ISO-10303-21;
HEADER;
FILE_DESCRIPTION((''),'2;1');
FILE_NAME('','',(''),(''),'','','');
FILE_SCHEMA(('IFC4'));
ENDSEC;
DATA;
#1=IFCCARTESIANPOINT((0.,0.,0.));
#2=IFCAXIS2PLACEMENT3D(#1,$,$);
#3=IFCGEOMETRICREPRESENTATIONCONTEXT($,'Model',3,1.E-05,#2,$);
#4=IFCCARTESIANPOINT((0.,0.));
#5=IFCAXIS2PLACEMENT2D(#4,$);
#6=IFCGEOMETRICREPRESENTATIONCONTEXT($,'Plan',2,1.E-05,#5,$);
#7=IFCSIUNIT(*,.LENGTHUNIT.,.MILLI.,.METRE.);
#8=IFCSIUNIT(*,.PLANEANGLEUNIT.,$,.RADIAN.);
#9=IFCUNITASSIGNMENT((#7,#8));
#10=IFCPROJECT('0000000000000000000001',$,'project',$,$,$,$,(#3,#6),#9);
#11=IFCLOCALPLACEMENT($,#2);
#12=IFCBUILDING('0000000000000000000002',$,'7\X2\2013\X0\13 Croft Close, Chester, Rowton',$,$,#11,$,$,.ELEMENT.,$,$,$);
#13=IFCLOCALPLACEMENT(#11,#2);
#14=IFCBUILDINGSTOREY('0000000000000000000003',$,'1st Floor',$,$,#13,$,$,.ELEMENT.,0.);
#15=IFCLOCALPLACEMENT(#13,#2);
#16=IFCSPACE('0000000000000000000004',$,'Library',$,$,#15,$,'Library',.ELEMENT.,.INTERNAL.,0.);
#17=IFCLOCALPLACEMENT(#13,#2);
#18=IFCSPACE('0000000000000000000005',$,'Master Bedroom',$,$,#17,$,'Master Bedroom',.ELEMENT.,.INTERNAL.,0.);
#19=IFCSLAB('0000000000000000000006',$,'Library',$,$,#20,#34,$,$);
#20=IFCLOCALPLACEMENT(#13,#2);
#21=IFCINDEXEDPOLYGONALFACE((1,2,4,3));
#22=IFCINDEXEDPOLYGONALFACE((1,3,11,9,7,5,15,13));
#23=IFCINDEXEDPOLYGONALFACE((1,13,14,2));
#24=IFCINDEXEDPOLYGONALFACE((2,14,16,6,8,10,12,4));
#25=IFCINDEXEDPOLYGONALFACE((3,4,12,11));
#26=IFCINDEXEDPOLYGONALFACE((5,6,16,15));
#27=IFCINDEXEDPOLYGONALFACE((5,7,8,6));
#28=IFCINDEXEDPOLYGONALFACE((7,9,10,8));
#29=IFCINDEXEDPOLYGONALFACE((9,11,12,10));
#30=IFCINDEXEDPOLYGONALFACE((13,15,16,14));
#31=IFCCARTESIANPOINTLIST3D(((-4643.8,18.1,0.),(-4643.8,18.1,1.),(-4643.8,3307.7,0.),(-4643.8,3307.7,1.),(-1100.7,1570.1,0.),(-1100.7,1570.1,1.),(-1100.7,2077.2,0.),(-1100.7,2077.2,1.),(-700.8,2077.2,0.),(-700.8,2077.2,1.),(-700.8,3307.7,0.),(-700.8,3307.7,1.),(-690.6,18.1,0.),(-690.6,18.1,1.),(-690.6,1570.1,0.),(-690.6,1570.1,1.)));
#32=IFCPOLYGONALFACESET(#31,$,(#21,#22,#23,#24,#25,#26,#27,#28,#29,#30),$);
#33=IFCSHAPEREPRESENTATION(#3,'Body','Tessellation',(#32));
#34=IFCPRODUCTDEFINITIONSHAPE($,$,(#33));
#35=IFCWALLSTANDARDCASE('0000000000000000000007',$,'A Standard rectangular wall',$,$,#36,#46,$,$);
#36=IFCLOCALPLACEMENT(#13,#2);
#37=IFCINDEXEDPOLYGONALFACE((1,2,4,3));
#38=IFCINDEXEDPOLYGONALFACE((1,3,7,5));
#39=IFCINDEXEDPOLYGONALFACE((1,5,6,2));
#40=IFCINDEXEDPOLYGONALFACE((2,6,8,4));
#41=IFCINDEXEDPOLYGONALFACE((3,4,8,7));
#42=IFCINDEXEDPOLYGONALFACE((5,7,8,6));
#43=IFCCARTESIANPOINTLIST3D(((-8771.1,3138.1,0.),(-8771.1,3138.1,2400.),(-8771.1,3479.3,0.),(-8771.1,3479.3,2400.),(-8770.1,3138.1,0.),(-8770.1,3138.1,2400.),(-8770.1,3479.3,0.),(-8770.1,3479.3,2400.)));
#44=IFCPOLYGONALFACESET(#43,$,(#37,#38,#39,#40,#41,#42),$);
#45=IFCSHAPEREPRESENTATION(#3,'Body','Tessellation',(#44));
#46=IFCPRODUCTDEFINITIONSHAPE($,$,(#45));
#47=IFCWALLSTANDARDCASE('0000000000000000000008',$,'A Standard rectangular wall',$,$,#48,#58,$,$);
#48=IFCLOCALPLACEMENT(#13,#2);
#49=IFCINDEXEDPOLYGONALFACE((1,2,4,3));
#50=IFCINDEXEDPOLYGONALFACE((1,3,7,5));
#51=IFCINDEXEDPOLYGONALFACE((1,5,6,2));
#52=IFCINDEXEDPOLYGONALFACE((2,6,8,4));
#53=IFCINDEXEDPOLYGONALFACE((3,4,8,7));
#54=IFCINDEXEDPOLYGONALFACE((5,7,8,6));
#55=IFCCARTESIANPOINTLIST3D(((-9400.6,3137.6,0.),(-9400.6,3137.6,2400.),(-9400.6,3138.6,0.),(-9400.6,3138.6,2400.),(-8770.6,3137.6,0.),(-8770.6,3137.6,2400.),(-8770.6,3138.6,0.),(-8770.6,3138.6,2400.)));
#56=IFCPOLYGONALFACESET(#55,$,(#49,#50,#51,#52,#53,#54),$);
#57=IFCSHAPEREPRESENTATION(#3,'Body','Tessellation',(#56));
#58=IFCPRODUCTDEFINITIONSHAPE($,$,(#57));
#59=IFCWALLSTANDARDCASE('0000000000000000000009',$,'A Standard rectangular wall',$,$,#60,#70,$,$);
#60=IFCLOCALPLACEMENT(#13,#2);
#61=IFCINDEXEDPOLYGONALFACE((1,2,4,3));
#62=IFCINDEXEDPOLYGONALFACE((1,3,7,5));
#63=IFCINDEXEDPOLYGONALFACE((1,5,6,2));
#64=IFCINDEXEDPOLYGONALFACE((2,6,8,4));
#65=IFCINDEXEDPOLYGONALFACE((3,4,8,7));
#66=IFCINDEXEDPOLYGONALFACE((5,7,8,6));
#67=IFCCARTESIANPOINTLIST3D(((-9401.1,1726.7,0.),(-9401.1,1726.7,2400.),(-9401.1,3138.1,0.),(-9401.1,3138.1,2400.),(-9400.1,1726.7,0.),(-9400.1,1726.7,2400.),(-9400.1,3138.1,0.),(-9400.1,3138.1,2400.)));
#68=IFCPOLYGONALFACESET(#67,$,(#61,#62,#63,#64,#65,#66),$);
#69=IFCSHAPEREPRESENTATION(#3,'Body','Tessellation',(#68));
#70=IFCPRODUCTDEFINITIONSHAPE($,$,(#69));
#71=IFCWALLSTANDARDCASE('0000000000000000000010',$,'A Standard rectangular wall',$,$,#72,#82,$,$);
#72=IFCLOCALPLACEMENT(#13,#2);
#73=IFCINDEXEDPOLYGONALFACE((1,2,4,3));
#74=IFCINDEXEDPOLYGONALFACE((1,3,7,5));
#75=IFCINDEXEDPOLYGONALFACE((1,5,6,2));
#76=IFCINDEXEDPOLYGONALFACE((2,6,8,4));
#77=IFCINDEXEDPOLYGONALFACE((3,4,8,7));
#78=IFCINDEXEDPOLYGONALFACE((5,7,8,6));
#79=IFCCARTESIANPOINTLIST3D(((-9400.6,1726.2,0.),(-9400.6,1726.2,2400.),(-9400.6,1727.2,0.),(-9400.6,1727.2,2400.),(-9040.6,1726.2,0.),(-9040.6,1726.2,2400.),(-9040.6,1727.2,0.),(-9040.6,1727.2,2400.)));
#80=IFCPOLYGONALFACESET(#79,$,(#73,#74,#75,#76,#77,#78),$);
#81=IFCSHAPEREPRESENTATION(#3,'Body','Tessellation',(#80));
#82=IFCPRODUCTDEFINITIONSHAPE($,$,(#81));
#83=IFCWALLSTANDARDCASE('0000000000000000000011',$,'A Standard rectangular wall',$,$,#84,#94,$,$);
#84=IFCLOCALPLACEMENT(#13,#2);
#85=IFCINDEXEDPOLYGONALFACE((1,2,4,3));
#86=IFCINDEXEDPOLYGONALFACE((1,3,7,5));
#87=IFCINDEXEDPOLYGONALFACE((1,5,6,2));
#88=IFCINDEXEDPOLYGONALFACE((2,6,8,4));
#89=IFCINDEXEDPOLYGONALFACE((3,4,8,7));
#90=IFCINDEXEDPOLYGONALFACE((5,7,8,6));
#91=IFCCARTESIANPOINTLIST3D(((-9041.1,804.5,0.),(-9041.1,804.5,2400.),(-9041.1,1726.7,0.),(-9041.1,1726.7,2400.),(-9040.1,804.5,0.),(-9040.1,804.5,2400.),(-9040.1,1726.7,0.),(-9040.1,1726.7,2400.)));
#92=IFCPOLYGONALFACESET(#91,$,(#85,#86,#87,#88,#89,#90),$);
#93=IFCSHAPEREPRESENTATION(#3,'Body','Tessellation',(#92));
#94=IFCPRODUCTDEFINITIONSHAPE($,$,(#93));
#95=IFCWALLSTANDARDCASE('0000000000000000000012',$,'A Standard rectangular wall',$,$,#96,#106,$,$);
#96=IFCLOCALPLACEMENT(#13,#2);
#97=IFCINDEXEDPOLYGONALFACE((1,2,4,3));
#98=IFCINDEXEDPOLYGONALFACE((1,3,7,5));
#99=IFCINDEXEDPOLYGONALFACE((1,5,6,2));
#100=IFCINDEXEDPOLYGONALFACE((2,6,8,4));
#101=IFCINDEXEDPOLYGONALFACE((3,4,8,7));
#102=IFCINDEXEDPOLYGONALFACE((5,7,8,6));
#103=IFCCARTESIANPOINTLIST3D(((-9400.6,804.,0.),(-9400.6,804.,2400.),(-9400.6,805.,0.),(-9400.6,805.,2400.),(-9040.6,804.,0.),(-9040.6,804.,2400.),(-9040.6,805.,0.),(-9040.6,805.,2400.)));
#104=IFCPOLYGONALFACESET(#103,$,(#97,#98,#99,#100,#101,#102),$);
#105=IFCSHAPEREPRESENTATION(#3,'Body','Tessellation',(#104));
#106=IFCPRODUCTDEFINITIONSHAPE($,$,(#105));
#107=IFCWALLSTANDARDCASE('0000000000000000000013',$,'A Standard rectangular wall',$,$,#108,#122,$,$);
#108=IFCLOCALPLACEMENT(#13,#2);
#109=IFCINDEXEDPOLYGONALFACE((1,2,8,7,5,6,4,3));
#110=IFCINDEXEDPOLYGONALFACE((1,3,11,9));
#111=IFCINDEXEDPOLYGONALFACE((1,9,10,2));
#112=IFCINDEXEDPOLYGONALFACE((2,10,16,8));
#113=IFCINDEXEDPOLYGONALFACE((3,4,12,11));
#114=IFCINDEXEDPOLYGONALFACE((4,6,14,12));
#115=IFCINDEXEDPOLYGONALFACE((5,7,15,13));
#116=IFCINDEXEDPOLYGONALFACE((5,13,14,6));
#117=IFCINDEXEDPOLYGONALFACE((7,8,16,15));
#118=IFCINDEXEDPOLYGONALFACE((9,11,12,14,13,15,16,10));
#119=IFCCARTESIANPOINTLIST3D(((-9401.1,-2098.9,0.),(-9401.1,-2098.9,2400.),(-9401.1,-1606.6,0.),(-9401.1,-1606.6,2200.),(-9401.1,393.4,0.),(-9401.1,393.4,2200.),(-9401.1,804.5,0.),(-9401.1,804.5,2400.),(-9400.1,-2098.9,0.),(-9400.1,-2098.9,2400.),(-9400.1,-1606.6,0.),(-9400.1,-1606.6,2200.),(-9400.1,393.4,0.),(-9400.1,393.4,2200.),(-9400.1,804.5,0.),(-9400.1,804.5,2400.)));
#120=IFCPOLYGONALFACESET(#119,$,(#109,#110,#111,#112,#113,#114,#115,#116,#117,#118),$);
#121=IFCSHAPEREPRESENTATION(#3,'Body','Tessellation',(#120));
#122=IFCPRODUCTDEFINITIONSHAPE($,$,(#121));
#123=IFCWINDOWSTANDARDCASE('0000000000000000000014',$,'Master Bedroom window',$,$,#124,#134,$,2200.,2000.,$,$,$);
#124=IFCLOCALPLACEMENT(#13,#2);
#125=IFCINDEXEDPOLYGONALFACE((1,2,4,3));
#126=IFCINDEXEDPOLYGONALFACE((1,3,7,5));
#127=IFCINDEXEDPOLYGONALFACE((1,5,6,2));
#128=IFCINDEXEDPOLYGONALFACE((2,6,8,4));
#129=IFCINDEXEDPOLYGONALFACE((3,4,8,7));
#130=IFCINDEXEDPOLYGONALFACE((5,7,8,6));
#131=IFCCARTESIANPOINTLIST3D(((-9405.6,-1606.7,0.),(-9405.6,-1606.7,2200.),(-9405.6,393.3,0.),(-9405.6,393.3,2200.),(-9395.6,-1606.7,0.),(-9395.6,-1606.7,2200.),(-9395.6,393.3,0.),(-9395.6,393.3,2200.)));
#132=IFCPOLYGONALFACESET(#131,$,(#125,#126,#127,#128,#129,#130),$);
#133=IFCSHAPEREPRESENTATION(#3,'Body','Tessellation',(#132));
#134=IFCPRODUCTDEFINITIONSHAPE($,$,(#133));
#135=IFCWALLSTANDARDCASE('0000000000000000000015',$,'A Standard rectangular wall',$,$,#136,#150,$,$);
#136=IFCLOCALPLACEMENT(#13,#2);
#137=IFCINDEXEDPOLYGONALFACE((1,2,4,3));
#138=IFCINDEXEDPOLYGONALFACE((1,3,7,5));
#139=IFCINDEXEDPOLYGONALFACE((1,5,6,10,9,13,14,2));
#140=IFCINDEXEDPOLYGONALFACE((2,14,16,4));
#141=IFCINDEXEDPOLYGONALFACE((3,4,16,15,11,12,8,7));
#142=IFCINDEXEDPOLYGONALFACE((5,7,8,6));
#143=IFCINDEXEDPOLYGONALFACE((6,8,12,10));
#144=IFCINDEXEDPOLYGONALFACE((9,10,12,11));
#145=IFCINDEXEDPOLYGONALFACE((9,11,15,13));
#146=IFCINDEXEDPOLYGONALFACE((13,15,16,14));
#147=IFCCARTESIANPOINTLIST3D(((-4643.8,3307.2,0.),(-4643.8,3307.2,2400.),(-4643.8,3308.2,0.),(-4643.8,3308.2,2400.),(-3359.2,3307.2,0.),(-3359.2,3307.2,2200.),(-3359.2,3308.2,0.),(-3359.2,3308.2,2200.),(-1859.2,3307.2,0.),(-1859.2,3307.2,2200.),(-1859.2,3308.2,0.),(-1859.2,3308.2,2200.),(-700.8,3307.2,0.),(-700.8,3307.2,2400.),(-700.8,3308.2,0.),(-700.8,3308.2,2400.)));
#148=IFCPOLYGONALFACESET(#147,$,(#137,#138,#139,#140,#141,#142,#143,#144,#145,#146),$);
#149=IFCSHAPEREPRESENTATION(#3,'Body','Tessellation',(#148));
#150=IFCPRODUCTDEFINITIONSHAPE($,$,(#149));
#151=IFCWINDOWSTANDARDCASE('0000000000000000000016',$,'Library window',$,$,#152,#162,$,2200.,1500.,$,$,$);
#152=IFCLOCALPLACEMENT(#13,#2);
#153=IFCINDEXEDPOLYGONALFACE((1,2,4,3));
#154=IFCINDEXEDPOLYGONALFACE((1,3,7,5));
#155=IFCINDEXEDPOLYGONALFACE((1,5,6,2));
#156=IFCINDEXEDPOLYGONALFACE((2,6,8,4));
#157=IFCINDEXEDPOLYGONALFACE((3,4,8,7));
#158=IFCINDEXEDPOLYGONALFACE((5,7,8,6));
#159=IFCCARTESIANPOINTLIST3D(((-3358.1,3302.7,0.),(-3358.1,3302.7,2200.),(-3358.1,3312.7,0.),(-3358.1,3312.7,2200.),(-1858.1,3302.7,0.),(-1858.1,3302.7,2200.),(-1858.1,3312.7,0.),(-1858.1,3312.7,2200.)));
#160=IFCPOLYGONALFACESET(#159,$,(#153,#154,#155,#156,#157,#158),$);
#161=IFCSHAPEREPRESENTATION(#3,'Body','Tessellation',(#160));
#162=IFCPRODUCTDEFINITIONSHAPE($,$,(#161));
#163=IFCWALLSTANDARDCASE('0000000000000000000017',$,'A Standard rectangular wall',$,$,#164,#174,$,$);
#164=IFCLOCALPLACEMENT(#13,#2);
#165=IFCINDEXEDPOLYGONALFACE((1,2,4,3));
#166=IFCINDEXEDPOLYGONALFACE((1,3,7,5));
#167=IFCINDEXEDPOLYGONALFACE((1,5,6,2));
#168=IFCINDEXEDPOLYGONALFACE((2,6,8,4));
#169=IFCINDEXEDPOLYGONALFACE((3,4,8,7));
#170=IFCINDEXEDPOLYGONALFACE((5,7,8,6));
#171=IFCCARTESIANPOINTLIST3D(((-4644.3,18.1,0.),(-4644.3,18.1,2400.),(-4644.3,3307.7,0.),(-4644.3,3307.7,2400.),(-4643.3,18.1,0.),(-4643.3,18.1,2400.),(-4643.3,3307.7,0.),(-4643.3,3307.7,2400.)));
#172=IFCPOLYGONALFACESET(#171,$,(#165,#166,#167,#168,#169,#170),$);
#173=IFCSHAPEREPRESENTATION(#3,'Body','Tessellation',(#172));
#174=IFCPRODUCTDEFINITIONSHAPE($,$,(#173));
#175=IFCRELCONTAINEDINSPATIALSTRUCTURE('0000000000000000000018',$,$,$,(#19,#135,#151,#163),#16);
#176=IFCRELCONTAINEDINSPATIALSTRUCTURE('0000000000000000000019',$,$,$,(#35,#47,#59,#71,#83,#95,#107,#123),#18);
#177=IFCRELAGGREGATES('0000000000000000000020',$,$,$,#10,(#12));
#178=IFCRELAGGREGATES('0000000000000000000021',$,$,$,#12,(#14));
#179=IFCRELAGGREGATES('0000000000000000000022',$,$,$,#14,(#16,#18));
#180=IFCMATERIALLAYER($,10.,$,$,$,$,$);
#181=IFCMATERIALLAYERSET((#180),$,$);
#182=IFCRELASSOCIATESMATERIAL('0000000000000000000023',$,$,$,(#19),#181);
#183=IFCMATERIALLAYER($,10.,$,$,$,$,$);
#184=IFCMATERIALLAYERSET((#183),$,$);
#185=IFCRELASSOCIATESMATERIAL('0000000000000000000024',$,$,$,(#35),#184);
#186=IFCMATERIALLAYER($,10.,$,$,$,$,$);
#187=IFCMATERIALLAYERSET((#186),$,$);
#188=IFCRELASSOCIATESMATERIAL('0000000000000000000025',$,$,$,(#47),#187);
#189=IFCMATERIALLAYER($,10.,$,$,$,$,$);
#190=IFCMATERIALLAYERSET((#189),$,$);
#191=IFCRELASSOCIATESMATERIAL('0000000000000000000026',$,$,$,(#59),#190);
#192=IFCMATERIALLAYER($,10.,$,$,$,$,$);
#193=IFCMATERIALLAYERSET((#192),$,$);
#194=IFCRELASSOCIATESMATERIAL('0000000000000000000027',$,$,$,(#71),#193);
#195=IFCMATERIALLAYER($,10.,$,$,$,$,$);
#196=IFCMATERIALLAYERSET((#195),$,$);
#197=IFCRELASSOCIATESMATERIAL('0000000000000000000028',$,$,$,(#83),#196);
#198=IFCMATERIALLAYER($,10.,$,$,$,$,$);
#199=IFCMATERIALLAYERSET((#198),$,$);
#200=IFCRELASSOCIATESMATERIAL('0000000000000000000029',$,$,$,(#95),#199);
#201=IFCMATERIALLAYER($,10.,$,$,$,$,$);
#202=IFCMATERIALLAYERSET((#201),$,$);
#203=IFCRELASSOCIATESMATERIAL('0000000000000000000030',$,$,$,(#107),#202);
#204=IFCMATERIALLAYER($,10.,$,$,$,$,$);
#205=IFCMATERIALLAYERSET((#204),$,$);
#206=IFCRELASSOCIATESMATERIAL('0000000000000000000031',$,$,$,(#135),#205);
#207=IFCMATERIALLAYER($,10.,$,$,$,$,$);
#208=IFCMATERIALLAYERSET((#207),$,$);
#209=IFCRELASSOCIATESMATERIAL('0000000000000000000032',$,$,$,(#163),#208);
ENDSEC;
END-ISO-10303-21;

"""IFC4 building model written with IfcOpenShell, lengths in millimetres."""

from ifc_helpers import new_model, si_unit, frame, origin, origin_2d, place, context, project, spatial, polyline, rectangle, outline, extrude, layer, layer_set, layer_usage, element, fill, save


model = new_model("IFC4")

# Units and contexts
model_context = context("Model", 3, precision=1e-05, world=origin())
plan_context = context("Plan", 2, precision=1e-05, world=origin_2d())
ifc_project = project(units=[si_unit("LENGTHUNIT", "METRE", prefix="MILLI"), si_unit("PLANEANGLEUNIT", "RADIAN")], contexts=[model_context, plan_context])

# Building, storey, space
building_placement = place(None, origin())
building = spatial("IfcBuilding", under=ifc_project, at=building_placement, Name="7–13 Croft Close, Chester, Rowton", CompositionType="ELEMENT")
storey_placement = place(building_placement, origin())
storey = spatial("IfcBuildingStorey", under=building, at=storey_placement, Name="1st Floor", CompositionType="ELEMENT", Elevation=0.0)
space_1_placement = place(storey_placement, origin())
space_1 = spatial("IfcSpace", under=storey, at=space_1_placement, Name="Library", LongName="Library", CompositionType="ELEMENT", PredefinedType="INTERNAL", ElevationWithFlooring=0.0)

# Slab
ifc_layer_1 = layer(None, 10.0)
ifc_layer_set_1 = layer_set([ifc_layer_1])
ifc_layer_usage_1 = layer_usage(ifc_layer_set_1, "AXIS2", "NEGATIVE", 150.0)
slab_placement = place(storey_placement, origin())
element("IfcSlab", 1, at=slab_placement, inside=space_1, material=ifc_layer_usage_1, Name="Library", context=model_context, shape_type="SweptSolid", body=[
    extrude(outline(polyline([(-690.6, 18.1), (-690.6, 1570.1), (-1100.7, 1570.1), (-1100.7, 2077.2), (-700.8, 2077.2), (-700.8, 3307.7), (-4643.8, 3307.7), (-4643.8, 18.1), (-690.6, 18.1)])), origin(), (0.0, 0.0, 1.0), 1.0),
])

# Shared definitions
space_2_placement = place(storey_placement, origin())
space_2 = spatial("IfcSpace", under=storey, at=space_2_placement, Name="Master Bedroom", LongName="Master Bedroom", CompositionType="ELEMENT", PredefinedType="INTERNAL", ElevationWithFlooring=0.0)

# Walls
ifc_layer_2 = layer(None, 10.0)
ifc_layer_set_2 = layer_set([ifc_layer_2])
ifc_layer_usage_2 = layer_usage(ifc_layer_set_2, "AXIS2", "NEGATIVE", 150.0)
wall_1_placement = place(storey_placement, origin())
element("IfcWallStandardCase", 2, at=wall_1_placement, inside=space_2, material=ifc_layer_usage_2, Name="A Standard rectangular wall", context=model_context, shape_type="SweptSolid", body=[
    extrude(rectangle(XDim=1.0, YDim=341.2, at=origin_2d()), frame((-8770.6, 3308.7, 0.0), x_axis=(1.0, 0.0, 0.0)), (0.0, 0.0, 1.0), 2400.0),
])
ifc_layer_3 = layer(None, 10.0)
ifc_layer_set_3 = layer_set([ifc_layer_3])
ifc_layer_usage_3 = layer_usage(ifc_layer_set_3, "AXIS2", "NEGATIVE", 150.0)
wall_2_placement = place(storey_placement, origin())
element("IfcWallStandardCase", 3, at=wall_2_placement, inside=space_2, material=ifc_layer_usage_3, Name="A Standard rectangular wall", context=model_context, shape_type="SweptSolid", body=[
    extrude(rectangle(XDim=1.0, YDim=630.0, at=origin_2d()), frame((-9085.6, 3138.1, 0.0), x_axis=(0.0, -1.0, 0.0)), (0.0, 0.0, 1.0), 2400.0),
])
ifc_layer_4 = layer(None, 10.0)
ifc_layer_set_4 = layer_set([ifc_layer_4])
ifc_layer_usage_4 = layer_usage(ifc_layer_set_4, "AXIS2", "NEGATIVE", 150.0)
wall_3_placement = place(storey_placement, origin())
element("IfcWallStandardCase", 4, at=wall_3_placement, inside=space_2, material=ifc_layer_usage_4, Name="A Standard rectangular wall", context=model_context, shape_type="SweptSolid", body=[
    extrude(rectangle(XDim=1.0, YDim=1411.4, at=origin_2d()), frame((-9400.6, 2432.4, 0.0), x_axis=(1.0, 0.0, 0.0)), (0.0, 0.0, 1.0), 2400.0),
])
ifc_layer_5 = layer(None, 10.0)
ifc_layer_set_5 = layer_set([ifc_layer_5])
ifc_layer_usage_5 = layer_usage(ifc_layer_set_5, "AXIS2", "NEGATIVE", 150.0)
wall_4_placement = place(storey_placement, origin())
element("IfcWallStandardCase", 5, at=wall_4_placement, inside=space_2, material=ifc_layer_usage_5, Name="A Standard rectangular wall", context=model_context, shape_type="SweptSolid", body=[
    extrude(rectangle(XDim=1.0, YDim=360.0, at=origin_2d()), frame((-9220.6, 1726.7, 0.0), x_axis=(0.0, 1.0, 0.0)), (0.0, 0.0, 1.0), 2400.0),
])
ifc_layer_6 = layer(None, 10.0)
ifc_layer_set_6 = layer_set([ifc_layer_6])
ifc_layer_usage_6 = layer_usage(ifc_layer_set_6, "AXIS2", "NEGATIVE", 150.0)
wall_5_placement = place(storey_placement, origin())
element("IfcWallStandardCase", 6, at=wall_5_placement, inside=space_2, material=ifc_layer_usage_6, Name="A Standard rectangular wall", context=model_context, shape_type="SweptSolid", body=[
    extrude(rectangle(XDim=1.0, YDim=922.2, at=origin_2d()), frame((-9040.6, 1265.6, 0.0), x_axis=(1.0, 0.0, 0.0)), (0.0, 0.0, 1.0), 2400.0),
])
ifc_layer_7 = layer(None, 10.0)
ifc_layer_set_7 = layer_set([ifc_layer_7])
ifc_layer_usage_7 = layer_usage(ifc_layer_set_7, "AXIS2", "NEGATIVE", 150.0)
wall_6_placement = place(storey_placement, origin())
element("IfcWallStandardCase", 7, at=wall_6_placement, inside=space_2, material=ifc_layer_usage_7, Name="A Standard rectangular wall", context=model_context, shape_type="SweptSolid", body=[
    extrude(rectangle(XDim=1.0, YDim=360.0, at=origin_2d()), frame((-9220.6, 804.5, 0.0), x_axis=(0.0, -1.0, 0.0)), (0.0, 0.0, 1.0), 2400.0),
])

# Walls, openings, windows
ifc_layer_8 = layer(None, 10.0)
ifc_layer_set_8 = layer_set([ifc_layer_8])
ifc_layer_usage_8 = layer_usage(ifc_layer_set_8, "AXIS2", "NEGATIVE", 150.0)
wall_7_placement = place(storey_placement, origin())
wall_7 = element("IfcWallStandardCase", 8, at=wall_7_placement, inside=space_2, material=ifc_layer_usage_8, Name="A Standard rectangular wall", context=model_context, shape_type="SweptSolid", body=[
    extrude(rectangle(XDim=1.0, YDim=2903.4, at=origin_2d()), frame((-9400.6, -647.2, 0.0), x_axis=(1.0, 0.0, 0.0)), (0.0, 0.0, 1.0), 2400.0),
])
opening_1_placement = place(storey_placement, origin())
opening_1 = element("IfcOpeningElement", 9, at=opening_1_placement, cuts=wall_7, context=model_context, shape_type="SweptSolid", body=[
    extrude(rectangle(XDim=10.0, YDim=2000.0, at=origin_2d()), frame((-9400.6, -606.6, 0.0), x_axis=(1.0, 0.0, 0.0)), (0.0, 0.0, 1.0), 2200.0),
])
window_1_placement = place(storey_placement, frame((0.0, -0.1, 0.0)))
window_1 = element("IfcWindowStandardCase", 10, at=window_1_placement, inside=space_2, Name="Master Bedroom window", OverallHeight=2200.0, OverallWidth=2000.0, context=model_context, shape_type="SweptSolid", body=[
    extrude(rectangle(XDim=10.0, YDim=2000.0, at=origin_2d()), frame((-9400.6, -606.6, 0.0), x_axis=(1.0, 0.0, 0.0)), (0.0, 0.0, 1.0), 2200.0),
])
fill(opening_1, window_1)
ifc_layer_9 = layer(None, 10.0)
ifc_layer_set_9 = layer_set([ifc_layer_9])
ifc_layer_usage_9 = layer_usage(ifc_layer_set_9, "AXIS2", "NEGATIVE", 150.0)
wall_8_placement = place(storey_placement, origin())
wall_8 = element("IfcWallStandardCase", 11, at=wall_8_placement, inside=space_1, material=ifc_layer_usage_9, Name="A Standard rectangular wall", context=model_context, shape_type="SweptSolid", body=[
    extrude(rectangle(XDim=1.0, YDim=3943.0, at=origin_2d()), frame((-2672.3, 3307.7, 0.0), x_axis=(0.0, -1.0, 0.0)), (0.0, 0.0, 1.0), 2400.0),
])
opening_2_placement = place(storey_placement, origin())
opening_2 = element("IfcOpeningElement", 12, at=opening_2_placement, cuts=wall_8, context=model_context, shape_type="SweptSolid", body=[
    extrude(rectangle(XDim=10.0, YDim=1500.0, at=origin_2d()), frame((-2609.2, 3307.7, 0.0), x_axis=(0.0, 1.0, 0.0)), (0.0, 0.0, 1.0), 2200.0),
])
window_2_placement = place(storey_placement, frame((1.1, 0.0, 0.0)))
window_2 = element("IfcWindowStandardCase", 13, at=window_2_placement, inside=space_1, Name="Library window", OverallHeight=2200.0, OverallWidth=1500.0, context=model_context, shape_type="SweptSolid", body=[
    extrude(rectangle(XDim=10.0, YDim=1500.0, at=origin_2d()), frame((-2609.2, 3307.7, 0.0), x_axis=(0.0, 1.0, 0.0)), (0.0, 0.0, 1.0), 2200.0),
])
fill(opening_2, window_2)

# Wall
ifc_layer_10 = layer(None, 10.0)
ifc_layer_set_10 = layer_set([ifc_layer_10])
ifc_layer_usage_10 = layer_usage(ifc_layer_set_10, "AXIS2", "NEGATIVE", 150.0)
wall_9_placement = place(storey_placement, origin())
element("IfcWallStandardCase", 14, at=wall_9_placement, inside=space_1, material=ifc_layer_usage_10, Name="A Standard rectangular wall", context=model_context, shape_type="SweptSolid", body=[
    extrude(rectangle(XDim=1.0, YDim=3289.6, at=origin_2d()), frame((-4643.8, 1662.9, 0.0), x_axis=(1.0, 0.0, 0.0)), (0.0, 0.0, 1.0), 2400.0),
])

save(model, "model.ifc")
